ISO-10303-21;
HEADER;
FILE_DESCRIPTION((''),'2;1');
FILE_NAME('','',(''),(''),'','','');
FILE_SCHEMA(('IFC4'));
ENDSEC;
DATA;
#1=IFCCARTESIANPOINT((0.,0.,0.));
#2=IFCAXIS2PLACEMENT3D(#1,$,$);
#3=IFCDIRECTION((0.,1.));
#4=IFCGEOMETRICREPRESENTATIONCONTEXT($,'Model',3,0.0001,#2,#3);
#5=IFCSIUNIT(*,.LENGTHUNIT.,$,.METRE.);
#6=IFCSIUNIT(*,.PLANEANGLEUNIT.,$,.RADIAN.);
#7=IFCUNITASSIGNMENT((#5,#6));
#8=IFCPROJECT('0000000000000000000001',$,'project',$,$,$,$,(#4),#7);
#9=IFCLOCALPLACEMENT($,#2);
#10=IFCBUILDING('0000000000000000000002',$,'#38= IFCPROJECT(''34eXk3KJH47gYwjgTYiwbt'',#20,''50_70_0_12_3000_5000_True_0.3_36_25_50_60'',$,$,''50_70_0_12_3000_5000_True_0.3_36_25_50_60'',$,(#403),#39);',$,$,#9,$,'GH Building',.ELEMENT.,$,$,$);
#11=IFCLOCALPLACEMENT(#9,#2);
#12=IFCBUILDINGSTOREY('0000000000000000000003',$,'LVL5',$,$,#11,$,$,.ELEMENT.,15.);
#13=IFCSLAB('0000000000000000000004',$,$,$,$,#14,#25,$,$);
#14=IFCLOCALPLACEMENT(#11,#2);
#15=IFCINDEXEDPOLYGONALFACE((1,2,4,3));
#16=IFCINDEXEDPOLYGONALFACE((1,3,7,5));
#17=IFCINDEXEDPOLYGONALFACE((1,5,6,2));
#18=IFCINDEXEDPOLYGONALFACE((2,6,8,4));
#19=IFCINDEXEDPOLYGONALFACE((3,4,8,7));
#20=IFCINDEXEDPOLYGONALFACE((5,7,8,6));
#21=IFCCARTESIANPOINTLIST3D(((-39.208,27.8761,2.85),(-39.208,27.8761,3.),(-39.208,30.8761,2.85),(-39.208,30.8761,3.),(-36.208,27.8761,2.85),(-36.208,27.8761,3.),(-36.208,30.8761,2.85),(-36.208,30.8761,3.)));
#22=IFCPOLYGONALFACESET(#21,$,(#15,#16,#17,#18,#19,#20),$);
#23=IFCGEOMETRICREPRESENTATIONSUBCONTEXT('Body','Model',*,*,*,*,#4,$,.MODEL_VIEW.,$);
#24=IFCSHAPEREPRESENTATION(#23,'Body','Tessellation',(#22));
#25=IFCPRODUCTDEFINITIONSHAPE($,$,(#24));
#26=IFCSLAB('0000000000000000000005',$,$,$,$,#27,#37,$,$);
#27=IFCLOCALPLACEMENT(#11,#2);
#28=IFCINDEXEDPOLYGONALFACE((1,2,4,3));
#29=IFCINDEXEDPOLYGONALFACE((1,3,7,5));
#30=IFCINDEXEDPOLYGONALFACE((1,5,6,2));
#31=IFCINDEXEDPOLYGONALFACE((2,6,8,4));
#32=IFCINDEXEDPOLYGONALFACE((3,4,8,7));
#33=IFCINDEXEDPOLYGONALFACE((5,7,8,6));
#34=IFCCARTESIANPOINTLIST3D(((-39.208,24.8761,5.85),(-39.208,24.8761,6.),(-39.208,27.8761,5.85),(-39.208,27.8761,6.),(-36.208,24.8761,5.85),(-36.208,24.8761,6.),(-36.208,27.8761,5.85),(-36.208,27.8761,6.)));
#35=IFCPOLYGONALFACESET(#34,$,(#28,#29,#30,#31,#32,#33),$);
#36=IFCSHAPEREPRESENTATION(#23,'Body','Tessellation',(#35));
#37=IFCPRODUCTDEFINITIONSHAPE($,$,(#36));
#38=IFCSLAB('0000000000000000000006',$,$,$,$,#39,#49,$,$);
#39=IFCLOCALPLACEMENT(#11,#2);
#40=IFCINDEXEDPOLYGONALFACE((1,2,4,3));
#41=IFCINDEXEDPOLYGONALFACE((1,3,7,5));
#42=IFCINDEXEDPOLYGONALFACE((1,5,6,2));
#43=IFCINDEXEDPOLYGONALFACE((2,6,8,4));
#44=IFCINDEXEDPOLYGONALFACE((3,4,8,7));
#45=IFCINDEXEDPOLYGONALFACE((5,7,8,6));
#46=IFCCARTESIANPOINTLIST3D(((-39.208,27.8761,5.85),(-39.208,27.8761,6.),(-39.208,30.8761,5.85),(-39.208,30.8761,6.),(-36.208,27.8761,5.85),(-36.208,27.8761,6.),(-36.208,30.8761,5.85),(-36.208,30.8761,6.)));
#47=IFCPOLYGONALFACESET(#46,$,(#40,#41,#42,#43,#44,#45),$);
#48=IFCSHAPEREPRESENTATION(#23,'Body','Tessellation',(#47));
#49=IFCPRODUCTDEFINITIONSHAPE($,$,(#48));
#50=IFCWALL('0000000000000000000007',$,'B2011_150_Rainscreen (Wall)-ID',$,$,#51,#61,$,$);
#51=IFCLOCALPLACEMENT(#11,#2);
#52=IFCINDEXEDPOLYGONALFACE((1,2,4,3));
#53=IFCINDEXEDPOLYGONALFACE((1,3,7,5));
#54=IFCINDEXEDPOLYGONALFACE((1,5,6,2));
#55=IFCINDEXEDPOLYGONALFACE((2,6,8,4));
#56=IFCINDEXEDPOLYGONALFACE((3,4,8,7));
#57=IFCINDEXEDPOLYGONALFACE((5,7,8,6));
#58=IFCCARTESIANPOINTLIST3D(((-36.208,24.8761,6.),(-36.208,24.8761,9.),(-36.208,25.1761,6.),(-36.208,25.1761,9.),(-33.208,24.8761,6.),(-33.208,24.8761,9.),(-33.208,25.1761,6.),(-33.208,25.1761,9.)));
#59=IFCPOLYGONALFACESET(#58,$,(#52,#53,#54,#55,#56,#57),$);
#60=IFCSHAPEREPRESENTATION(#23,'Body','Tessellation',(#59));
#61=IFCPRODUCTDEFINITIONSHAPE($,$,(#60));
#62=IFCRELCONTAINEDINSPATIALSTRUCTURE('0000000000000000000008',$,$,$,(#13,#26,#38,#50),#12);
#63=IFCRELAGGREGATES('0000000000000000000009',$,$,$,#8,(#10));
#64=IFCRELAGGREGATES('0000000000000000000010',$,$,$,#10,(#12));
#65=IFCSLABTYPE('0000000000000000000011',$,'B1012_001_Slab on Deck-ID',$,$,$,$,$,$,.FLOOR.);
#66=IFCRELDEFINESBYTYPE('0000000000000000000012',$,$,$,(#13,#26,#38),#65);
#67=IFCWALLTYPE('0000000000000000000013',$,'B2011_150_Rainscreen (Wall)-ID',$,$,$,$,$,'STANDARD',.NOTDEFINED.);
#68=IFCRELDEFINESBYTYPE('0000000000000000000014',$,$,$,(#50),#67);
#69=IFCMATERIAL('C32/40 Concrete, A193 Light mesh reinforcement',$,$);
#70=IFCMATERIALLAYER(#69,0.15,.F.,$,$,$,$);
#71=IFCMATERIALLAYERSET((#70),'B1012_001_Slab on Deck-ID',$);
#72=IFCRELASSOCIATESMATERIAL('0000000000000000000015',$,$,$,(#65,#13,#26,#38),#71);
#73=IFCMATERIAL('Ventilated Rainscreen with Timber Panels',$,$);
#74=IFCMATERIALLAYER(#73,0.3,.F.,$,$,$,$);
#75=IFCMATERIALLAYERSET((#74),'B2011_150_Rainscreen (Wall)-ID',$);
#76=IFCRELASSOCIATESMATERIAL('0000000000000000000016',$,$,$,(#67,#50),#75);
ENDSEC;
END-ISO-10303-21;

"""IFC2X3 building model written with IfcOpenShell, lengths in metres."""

from ifc_helpers import new_model, si_unit, direction, frame, frame_2d, origin, place, context, subcontext, project, spatial, polyline, rectangle, outline, extrude, material, layer, layer_set, layer_usage, type_object, element, save


model = new_model("IFC2X3")

# Units and contexts
model_context = context("Model", 3, precision=0.0001, world=origin(), true_north=direction((0.0, 1.0)))
body_context = subcontext(model_context, "Body", "Model", "MODEL_VIEW")
ifc_project = project(units=[si_unit("LENGTHUNIT", "METRE"), si_unit("PLANEANGLEUNIT", "RADIAN")], contexts=[model_context])

# Building, storey
building_placement = place(None, origin())
building = spatial("IfcBuilding", under=ifc_project, at=building_placement, Name="#38= IFCPROJECT('34eXk3KJH47gYwjgTYiwbt',#20,'50_70_0_12_3000_5000_True_0.3_36_25_50_60',$,$,'50_70_0_12_3000_5000_True_0.3_36_25_50_60',$,(#403),#39);", LongName="GH Building", CompositionType="ELEMENT")
storey_placement = place(building_placement, origin())
storey = spatial("IfcBuildingStorey", under=building, at=storey_placement, Name="LVL5", CompositionType="ELEMENT", Elevation=15.0)

# Slabs
ifc_material_1 = material(Name="C32/40 Concrete, A193 Light mesh reinforcement")
ifc_layer_1 = layer(ifc_material_1, 0.15, ventilated=False)
ifc_layer_set_1 = layer_set([ifc_layer_1], Name="B1012_001_Slab on Deck-ID")
slab_type = type_object("IfcSlabType", Name="B1012_001_Slab on Deck-ID", PredefinedType="FLOOR", material=ifc_layer_set_1)
ifc_layer_usage_1 = layer_usage(ifc_layer_set_1, "AXIS3", "NEGATIVE", -0.15)
slab_1_placement = place(storey_placement, frame((-37.708, 29.3761, 2.85)))
element("IfcSlab", 1, at=slab_1_placement, inside=storey, type_object=slab_type, material=ifc_layer_usage_1, context=body_context, shape_type="SweptSolid", body=[
    extrude(outline(polyline([(-1.5, -1.5), (-1.5, 1.5), (1.5, 1.5), (1.5, -1.5), (-1.5, -1.5)])), origin(), (0.0, 0.0, 1.0), 0.15),
])
ifc_layer_usage_2 = layer_usage(ifc_layer_set_1, "AXIS3", "NEGATIVE", -0.15)
slab_2_placement = place(storey_placement, frame((-37.708, 26.3761, 5.85)))
element("IfcSlab", 2, at=slab_2_placement, inside=storey, type_object=slab_type, material=ifc_layer_usage_2, context=body_context, shape_type="SweptSolid", body=[
    extrude(outline(polyline([(1.5, 1.5), (1.5, -1.5), (-1.5, -1.5), (-1.5, 1.5), (1.5, 1.5)])), origin(), (0.0, 0.0, 1.0), 0.15),
])
ifc_layer_usage_3 = layer_usage(ifc_layer_set_1, "AXIS3", "NEGATIVE", -0.15)
slab_3_placement = place(storey_placement, frame((-37.708, 29.3761, 5.85)))
element("IfcSlab", 3, at=slab_3_placement, inside=storey, type_object=slab_type, material=ifc_layer_usage_3, context=body_context, shape_type="SweptSolid", body=[
    extrude(outline(polyline([(-1.5, -1.5), (-1.5, 1.5), (1.5, 1.5), (1.5, -1.5), (-1.5, -1.5)])), origin(), (0.0, 0.0, 1.0), 0.15),
])

# Wall
ifc_material_2 = material(Name="Ventilated Rainscreen with Timber Panels")
ifc_layer_2 = layer(ifc_material_2, 0.3, ventilated=False)
ifc_layer_set_2 = layer_set([ifc_layer_2], Name="B2011_150_Rainscreen (Wall)-ID")
ifc_layer_usage_4 = layer_usage(ifc_layer_set_2, "AXIS2", "POSITIVE", 0.0)
wall_type = type_object("IfcWallType", Name="B2011_150_Rainscreen (Wall)-ID", ElementType="STANDARD", PredefinedType="NOTDEFINED", material=ifc_layer_set_2)
wall_placement = place(storey_placement, frame((-36.208, 24.8761, 6.0)))
element("IfcWall", 4, at=wall_placement, inside=storey, type_object=wall_type, material=ifc_layer_usage_4, Name="B2011_150_Rainscreen (Wall)-ID", context=body_context, shape_type="SweptSolid", body=[
    extrude(rectangle(XDim=3.0, YDim=0.3, at=frame_2d((1.5, 0.15))), origin(), (0.0, 0.0, 1.0), 3.0),
])

save(model, "model.ifc")
